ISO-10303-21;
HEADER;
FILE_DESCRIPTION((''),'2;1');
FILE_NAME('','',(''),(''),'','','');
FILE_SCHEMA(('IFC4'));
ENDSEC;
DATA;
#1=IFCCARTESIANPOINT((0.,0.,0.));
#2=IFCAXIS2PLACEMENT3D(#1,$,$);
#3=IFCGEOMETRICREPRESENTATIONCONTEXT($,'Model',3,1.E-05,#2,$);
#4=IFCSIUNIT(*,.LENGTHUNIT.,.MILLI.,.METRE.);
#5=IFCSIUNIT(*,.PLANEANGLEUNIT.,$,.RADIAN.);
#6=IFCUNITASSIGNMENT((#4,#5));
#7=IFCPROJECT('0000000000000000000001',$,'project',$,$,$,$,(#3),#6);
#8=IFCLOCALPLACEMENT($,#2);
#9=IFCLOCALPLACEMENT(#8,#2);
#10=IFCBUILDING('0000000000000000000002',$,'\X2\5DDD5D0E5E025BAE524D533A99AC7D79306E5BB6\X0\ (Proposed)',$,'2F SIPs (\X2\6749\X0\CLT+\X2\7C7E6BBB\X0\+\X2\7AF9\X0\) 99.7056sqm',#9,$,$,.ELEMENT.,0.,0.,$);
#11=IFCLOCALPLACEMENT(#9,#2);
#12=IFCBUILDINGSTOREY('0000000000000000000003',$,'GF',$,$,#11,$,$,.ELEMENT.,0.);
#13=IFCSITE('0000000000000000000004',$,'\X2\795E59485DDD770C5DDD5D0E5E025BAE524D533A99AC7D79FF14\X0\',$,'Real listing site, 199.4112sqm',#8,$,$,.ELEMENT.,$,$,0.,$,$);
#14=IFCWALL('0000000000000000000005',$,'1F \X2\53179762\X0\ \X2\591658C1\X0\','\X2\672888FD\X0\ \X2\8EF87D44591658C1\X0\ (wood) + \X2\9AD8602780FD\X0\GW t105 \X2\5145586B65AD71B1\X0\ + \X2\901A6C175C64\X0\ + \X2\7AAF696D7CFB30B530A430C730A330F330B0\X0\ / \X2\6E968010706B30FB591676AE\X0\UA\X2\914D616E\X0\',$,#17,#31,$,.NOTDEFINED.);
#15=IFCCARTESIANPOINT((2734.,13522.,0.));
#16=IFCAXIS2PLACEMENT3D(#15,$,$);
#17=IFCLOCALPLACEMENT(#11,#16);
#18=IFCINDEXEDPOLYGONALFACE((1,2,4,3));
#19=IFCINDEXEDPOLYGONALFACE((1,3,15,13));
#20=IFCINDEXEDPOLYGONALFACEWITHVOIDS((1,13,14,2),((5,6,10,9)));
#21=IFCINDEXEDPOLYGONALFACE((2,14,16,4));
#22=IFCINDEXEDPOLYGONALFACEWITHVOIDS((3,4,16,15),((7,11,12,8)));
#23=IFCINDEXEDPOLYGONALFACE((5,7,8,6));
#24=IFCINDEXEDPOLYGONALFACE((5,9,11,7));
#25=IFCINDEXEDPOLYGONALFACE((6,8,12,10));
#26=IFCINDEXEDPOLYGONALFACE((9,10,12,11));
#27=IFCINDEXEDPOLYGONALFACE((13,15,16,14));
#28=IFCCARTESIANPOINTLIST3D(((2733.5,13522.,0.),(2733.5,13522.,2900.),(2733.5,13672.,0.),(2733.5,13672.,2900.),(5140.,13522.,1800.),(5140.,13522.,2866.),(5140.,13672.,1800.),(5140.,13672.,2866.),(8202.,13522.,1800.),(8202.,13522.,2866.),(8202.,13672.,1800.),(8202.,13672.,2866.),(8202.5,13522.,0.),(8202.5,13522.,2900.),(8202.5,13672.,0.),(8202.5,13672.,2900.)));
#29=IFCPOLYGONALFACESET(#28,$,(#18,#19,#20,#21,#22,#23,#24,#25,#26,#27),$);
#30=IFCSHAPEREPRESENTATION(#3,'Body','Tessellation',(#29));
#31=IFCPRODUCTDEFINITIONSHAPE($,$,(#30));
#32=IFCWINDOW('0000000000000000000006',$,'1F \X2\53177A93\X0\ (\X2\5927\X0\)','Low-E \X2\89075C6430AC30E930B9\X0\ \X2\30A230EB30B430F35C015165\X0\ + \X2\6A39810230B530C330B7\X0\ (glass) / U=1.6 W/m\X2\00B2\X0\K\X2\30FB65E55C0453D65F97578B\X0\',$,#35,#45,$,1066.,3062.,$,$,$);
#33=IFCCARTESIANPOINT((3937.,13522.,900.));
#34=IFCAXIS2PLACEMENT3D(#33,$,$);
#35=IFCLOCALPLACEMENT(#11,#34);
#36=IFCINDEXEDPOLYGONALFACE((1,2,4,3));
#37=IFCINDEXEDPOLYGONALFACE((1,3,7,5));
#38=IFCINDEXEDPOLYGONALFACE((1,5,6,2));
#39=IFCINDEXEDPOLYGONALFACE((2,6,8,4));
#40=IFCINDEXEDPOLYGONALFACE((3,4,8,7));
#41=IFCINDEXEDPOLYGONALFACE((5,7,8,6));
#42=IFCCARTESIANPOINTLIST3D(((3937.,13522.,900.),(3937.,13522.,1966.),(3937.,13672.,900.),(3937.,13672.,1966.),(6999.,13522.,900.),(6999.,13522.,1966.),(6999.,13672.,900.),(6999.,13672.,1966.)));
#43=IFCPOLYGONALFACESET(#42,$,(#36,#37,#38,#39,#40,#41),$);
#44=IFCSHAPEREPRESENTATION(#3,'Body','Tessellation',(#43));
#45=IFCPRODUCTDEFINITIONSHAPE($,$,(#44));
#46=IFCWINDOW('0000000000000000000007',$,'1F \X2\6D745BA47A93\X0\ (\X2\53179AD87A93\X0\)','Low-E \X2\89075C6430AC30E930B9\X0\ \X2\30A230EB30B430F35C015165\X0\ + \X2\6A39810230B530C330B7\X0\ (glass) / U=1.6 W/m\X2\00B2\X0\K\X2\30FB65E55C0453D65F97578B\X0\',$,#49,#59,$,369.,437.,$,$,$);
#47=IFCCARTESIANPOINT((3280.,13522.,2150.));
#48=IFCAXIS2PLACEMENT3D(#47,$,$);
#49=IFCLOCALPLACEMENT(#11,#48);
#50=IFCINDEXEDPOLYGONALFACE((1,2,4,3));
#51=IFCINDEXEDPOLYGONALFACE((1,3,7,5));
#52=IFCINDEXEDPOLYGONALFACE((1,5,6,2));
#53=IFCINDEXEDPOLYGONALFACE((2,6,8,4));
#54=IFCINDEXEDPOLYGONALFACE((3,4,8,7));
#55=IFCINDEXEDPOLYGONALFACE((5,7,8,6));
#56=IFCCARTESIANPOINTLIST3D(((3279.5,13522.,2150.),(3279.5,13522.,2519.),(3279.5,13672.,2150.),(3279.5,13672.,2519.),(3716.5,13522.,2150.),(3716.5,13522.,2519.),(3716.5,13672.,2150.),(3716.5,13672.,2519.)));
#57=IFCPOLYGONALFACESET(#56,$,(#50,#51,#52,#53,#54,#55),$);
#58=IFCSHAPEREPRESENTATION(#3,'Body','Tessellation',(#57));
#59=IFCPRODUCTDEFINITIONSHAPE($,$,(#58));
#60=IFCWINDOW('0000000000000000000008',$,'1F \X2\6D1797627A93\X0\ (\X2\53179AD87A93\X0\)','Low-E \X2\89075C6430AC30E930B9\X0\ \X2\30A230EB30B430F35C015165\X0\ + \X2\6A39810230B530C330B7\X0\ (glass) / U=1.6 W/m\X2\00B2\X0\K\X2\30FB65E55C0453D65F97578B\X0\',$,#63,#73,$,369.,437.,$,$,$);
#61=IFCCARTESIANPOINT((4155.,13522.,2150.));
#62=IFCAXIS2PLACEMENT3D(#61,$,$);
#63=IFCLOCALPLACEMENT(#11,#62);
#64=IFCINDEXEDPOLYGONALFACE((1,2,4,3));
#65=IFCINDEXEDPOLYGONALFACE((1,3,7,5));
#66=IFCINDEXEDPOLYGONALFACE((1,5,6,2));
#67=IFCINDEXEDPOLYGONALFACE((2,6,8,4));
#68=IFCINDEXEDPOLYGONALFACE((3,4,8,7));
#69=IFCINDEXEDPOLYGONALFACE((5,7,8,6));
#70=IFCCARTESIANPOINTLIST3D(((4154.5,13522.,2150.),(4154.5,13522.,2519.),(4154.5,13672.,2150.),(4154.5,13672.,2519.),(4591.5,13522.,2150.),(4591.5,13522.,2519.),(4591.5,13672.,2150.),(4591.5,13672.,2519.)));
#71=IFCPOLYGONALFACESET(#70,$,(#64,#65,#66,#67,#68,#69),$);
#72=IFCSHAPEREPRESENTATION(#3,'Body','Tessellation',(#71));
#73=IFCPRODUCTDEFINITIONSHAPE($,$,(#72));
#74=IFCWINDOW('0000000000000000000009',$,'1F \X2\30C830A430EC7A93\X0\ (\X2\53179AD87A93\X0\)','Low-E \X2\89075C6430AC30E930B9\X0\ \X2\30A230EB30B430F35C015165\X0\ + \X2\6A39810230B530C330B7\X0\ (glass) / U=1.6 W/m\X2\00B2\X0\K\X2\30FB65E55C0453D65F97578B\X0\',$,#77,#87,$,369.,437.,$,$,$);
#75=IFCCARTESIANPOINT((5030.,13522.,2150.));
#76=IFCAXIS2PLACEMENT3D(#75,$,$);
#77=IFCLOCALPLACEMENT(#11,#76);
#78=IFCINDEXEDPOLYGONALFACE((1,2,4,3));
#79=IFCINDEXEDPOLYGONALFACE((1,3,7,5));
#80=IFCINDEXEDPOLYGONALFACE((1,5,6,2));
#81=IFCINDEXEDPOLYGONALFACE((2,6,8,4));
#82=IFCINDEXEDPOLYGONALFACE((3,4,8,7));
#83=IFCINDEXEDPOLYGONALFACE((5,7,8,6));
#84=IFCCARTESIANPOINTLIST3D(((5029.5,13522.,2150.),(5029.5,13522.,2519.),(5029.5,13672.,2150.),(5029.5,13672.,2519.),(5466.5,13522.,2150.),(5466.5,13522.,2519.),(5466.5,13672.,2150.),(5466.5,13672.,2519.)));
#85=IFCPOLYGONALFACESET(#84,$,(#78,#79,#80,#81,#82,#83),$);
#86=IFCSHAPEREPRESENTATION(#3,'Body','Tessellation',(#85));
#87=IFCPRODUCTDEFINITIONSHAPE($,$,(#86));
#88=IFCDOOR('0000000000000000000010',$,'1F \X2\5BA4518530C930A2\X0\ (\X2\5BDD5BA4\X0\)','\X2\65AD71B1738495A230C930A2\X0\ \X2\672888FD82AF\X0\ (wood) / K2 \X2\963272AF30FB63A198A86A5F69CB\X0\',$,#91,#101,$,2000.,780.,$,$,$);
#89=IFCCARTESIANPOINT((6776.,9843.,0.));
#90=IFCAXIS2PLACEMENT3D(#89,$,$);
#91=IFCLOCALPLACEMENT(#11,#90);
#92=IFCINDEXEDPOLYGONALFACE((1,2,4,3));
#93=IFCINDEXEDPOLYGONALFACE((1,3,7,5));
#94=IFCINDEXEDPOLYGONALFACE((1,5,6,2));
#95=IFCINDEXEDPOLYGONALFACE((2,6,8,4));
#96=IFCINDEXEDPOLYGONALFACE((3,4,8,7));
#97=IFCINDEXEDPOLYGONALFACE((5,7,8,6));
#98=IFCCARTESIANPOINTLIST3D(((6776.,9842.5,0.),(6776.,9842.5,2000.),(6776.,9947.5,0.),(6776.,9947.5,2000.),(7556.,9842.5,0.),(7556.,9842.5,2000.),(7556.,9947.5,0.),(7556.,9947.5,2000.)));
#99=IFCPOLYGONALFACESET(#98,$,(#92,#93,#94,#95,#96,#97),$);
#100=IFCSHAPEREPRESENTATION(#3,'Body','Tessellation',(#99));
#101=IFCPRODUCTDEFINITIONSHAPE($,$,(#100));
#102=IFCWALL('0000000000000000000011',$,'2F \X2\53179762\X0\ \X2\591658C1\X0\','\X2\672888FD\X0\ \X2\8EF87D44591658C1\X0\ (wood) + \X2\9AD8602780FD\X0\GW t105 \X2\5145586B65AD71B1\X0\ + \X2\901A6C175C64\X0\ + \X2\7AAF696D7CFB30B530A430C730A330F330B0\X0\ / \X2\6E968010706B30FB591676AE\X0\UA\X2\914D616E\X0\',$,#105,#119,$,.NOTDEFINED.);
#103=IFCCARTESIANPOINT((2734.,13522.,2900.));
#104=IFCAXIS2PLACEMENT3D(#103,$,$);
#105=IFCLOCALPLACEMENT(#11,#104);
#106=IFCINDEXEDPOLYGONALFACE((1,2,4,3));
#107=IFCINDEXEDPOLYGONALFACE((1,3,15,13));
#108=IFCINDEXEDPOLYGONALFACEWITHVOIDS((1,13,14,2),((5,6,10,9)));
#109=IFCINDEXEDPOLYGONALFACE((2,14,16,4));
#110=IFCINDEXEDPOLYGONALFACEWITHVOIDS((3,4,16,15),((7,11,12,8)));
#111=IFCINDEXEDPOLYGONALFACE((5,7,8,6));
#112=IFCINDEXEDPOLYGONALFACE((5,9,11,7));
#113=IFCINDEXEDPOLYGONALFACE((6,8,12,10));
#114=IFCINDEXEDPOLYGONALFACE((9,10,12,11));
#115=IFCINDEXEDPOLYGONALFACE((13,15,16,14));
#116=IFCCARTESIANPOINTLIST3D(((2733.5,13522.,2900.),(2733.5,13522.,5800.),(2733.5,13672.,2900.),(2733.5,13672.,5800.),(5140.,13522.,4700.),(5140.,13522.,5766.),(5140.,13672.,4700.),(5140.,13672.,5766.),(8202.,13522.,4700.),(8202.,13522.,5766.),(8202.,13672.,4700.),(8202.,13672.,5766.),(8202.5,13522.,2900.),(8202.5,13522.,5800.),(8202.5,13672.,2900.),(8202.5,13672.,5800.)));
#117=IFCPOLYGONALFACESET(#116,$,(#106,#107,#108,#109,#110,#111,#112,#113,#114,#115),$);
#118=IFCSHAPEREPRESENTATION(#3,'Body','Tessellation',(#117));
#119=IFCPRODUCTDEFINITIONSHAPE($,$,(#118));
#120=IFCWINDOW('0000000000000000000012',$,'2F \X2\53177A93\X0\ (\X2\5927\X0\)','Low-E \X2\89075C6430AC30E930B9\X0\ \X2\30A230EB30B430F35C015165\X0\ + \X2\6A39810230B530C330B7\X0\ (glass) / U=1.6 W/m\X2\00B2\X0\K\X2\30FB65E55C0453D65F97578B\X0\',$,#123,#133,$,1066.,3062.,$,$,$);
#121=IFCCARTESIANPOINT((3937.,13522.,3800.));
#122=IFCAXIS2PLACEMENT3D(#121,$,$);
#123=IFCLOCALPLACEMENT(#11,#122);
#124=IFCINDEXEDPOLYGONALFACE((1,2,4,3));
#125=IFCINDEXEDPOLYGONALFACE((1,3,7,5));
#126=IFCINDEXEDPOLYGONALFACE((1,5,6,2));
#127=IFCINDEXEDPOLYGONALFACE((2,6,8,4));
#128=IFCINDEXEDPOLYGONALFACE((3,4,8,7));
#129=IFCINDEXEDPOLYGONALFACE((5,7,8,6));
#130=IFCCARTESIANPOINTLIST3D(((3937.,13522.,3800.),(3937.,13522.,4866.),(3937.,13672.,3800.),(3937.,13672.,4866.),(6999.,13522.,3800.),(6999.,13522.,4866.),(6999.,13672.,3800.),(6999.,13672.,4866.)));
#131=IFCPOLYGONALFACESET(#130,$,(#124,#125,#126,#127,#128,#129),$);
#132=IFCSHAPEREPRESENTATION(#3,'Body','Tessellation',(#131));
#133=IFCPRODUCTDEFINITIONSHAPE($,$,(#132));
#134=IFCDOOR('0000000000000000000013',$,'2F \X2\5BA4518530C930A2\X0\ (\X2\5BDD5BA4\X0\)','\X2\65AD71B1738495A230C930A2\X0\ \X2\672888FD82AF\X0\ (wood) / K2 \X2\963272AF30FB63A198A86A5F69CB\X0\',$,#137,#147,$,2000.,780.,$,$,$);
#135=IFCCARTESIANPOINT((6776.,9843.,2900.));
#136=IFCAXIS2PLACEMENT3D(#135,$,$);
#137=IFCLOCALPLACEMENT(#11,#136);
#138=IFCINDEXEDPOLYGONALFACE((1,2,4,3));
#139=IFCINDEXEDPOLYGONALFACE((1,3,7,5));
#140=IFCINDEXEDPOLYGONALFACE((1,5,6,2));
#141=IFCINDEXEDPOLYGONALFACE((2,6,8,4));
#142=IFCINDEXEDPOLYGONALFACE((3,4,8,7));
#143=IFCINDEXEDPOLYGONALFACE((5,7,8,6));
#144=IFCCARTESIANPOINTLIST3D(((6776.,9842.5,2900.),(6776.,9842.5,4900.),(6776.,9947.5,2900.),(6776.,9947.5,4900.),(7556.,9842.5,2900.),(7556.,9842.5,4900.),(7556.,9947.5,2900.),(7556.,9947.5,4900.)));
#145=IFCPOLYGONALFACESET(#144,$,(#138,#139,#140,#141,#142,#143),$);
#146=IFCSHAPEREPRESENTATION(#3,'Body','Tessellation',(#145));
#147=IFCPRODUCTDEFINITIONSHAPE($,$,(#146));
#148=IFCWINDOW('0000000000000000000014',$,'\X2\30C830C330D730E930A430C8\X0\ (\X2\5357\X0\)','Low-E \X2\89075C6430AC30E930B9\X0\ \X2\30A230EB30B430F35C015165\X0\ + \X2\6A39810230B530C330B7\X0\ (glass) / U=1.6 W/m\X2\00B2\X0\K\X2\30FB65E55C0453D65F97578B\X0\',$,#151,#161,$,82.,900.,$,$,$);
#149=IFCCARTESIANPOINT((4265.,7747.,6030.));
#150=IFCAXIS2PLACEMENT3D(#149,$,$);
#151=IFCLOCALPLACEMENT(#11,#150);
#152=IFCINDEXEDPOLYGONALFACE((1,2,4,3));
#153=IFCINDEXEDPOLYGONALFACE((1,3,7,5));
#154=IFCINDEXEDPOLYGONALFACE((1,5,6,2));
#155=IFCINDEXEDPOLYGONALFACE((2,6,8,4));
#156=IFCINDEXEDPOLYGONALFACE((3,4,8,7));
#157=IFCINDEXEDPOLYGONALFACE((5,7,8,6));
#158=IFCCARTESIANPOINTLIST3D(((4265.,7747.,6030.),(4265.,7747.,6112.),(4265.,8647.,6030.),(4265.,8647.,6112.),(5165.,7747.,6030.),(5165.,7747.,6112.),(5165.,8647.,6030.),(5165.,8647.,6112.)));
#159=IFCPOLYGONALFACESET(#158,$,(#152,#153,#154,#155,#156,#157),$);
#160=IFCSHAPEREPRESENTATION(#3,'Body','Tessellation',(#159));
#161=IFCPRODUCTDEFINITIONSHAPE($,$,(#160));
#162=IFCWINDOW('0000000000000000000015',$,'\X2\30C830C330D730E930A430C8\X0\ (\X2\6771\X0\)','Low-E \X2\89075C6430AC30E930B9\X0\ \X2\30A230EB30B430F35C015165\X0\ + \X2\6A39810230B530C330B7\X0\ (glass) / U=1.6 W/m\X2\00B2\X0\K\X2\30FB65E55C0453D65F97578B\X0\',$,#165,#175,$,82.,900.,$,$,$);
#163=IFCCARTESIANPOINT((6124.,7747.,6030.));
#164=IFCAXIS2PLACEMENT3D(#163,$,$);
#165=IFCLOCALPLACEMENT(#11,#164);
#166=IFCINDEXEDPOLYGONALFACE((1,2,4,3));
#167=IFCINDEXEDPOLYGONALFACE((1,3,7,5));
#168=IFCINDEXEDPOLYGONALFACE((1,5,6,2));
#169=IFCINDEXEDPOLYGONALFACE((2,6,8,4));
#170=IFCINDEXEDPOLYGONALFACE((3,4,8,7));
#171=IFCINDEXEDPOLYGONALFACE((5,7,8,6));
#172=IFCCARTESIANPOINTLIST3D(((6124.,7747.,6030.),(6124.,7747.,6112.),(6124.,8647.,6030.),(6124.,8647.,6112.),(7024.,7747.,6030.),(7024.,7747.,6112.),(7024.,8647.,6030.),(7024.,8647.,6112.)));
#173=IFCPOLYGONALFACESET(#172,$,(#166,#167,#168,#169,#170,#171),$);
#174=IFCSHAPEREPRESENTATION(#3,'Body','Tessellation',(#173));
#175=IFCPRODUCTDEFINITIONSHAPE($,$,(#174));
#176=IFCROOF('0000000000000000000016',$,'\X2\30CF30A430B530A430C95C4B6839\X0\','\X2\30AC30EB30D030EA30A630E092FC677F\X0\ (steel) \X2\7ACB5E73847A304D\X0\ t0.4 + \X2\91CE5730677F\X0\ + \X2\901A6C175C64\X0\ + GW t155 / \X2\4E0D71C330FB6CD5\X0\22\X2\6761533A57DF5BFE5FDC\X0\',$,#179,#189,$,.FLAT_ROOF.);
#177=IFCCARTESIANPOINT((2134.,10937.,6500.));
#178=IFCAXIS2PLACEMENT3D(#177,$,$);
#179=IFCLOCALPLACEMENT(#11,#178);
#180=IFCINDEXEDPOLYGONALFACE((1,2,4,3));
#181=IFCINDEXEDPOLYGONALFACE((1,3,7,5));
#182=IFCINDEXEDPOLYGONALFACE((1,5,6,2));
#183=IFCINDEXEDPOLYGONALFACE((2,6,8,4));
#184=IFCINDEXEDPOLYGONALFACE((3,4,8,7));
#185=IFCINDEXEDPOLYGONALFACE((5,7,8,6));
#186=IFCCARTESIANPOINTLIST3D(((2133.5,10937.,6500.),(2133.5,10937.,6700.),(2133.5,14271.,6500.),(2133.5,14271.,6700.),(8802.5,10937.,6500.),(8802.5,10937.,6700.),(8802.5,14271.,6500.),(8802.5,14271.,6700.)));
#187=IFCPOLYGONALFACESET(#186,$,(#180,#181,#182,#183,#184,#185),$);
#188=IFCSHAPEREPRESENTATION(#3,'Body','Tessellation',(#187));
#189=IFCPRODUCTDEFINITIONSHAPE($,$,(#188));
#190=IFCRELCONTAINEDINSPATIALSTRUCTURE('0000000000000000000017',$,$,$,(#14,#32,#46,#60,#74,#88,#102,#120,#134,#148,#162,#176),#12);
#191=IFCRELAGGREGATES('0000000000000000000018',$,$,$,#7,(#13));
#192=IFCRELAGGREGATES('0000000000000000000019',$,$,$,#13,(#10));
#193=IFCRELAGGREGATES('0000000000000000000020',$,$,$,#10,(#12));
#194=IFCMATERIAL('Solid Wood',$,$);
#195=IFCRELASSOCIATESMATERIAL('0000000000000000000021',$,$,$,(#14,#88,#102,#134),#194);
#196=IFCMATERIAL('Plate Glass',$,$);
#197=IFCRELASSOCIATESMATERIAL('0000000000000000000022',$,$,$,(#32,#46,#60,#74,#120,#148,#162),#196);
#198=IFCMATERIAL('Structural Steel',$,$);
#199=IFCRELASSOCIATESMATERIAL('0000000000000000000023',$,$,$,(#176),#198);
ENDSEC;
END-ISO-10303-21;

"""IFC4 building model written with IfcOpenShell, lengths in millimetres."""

from ifc_helpers import new_model, si_unit, frame, frame_2d, origin, place, context, project, spatial, rectangle, extrude, material, element, fill, save


model = new_model("IFC4")

# Units and contexts
model_context = context("Model", 3, precision=1e-05, world=origin())
ifc_project = project(units=[si_unit("LENGTHUNIT", "METRE", prefix="MILLI"), si_unit("PLANEANGLEUNIT", "RADIAN")], contexts=[model_context])

# Site, building, storey
site_placement = place(None, origin())
site = spatial("IfcSite", under=ifc_project, at=site_placement, Name="神奈川県川崎市宮前区馬絹４", ObjectType="Real listing site, 199.4112sqm", CompositionType="ELEMENT", RefElevation=0.0)
building_placement = place(site_placement, origin())
building = spatial("IfcBuilding", under=site, at=building_placement, Name="川崎市宮前区馬絹の家 (Proposed)", ObjectType="2F SIPs (杉CLT+籾殻+竹) 99.7056sqm", CompositionType="ELEMENT", ElevationOfRefHeight=0.0, ElevationOfTerrain=0.0)
storey_placement = place(building_placement, origin())
storey = spatial("IfcBuildingStorey", under=building, at=storey_placement, Name="GF", CompositionType="ELEMENT", Elevation=0.0)

# Wall, openings, windows
ifc_material_1 = material(Name="Solid Wood")
wall_1_placement = place(storey_placement, frame((2734.0, 13522.0, 0.0)))
wall_1 = element("IfcWall", 1, at=wall_1_placement, inside=storey, material=ifc_material_1, Name="1F 北面 外壁", Description="木製 軸組外壁 (wood) + 高性能GW t105 充填断熱 + 通気層 + 窯業系サイディング / 準耐火・外皮UA配慮", PredefinedType="NOTDEFINED", context=model_context, shape_type="SweptSolid", body=[
    extrude(rectangle(XDim=5469.0, YDim=150.0, at=frame_2d((2734.0, 75.0))), frame((2734.0, 13522.0, 0.0)), (0.0, 0.0, 1.0), 2900.0),
])
opening_1_placement = place(storey_placement, frame((3937.0, 13522.0, 900.0)))
opening_1 = element("IfcOpeningElement", 2, at=opening_1_placement, cuts=wall_1, PredefinedType="NOTDEFINED", context=model_context, shape_type="SweptSolid", body=[
    extrude(rectangle(XDim=3062.0, YDim=150.0, at=frame_2d((1531.0, 75.0))), frame((3937.0, 13522.0, 900.0)), (0.0, 0.0, 1.0), 1066.0),
])
opening_2_placement = place(storey_placement, frame((3280.0, 13522.0, 2150.0)))
opening_2 = element("IfcOpeningElement", 3, at=opening_2_placement, cuts=wall_1, PredefinedType="NOTDEFINED", context=model_context, shape_type="SweptSolid", body=[
    extrude(rectangle(XDim=437.0, YDim=150.0, at=frame_2d((218.0, 75.0))), frame((3280.0, 13522.0, 2150.0)), (0.0, 0.0, 1.0), 369.0),
])
opening_3_placement = place(storey_placement, frame((4155.0, 13522.0, 2150.0)))
opening_3 = element("IfcOpeningElement", 4, at=opening_3_placement, cuts=wall_1, PredefinedType="NOTDEFINED", context=model_context, shape_type="SweptSolid", body=[
    extrude(rectangle(XDim=437.0, YDim=150.0, at=frame_2d((218.0, 75.0))), frame((4155.0, 13522.0, 2150.0)), (0.0, 0.0, 1.0), 369.0),
])
opening_4_placement = place(storey_placement, frame((5030.0, 13522.0, 2150.0)))
opening_4 = element("IfcOpeningElement", 5, at=opening_4_placement, cuts=wall_1, PredefinedType="NOTDEFINED", context=model_context, shape_type="SweptSolid", body=[
    extrude(rectangle(XDim=437.0, YDim=150.0, at=frame_2d((218.0, 75.0))), frame((5030.0, 13522.0, 2150.0)), (0.0, 0.0, 1.0), 369.0),
])
ifc_material_2 = material(Name="Plate Glass")
window_1_placement = place(storey_placement, frame((3937.0, 13522.0, 900.0)))
window_1 = element("IfcWindow", 6, at=window_1_placement, inside=storey, material=ifc_material_2, Name="1F 北窓 (大)", Description="Low-E 複層ガラス アルゴン封入 + 樹脂サッシ (glass) / U=1.6 W/m²K・日射取得型", OverallHeight=1066.0, OverallWidth=3062.0, context=model_context, shape_type="SweptSolid", body=[
    extrude(rectangle(XDim=3062.0, YDim=150.0, at=frame_2d((1531.0, 75.0))), frame((3937.0, 13522.0, 900.0)), (0.0, 0.0, 1.0), 1066.0),
])
fill(opening_1, window_1)
window_2_placement = place(storey_placement, frame((3280.0, 13522.0, 2150.0)))
window_2 = element("IfcWindow", 7, at=window_2_placement, inside=storey, material=ifc_material_2, Name="1F 浴室窓 (北高窓)", Description="Low-E 複層ガラス アルゴン封入 + 樹脂サッシ (glass) / U=1.6 W/m²K・日射取得型", OverallHeight=369.0, OverallWidth=437.0, context=model_context, shape_type="SweptSolid", body=[
    extrude(rectangle(XDim=437.0, YDim=150.0, at=frame_2d((218.0, 75.0))), frame((3280.0, 13522.0, 2150.0)), (0.0, 0.0, 1.0), 369.0),
])
fill(opening_2, window_2)
window_3_placement = place(storey_placement, frame((4155.0, 13522.0, 2150.0)))
window_3 = element("IfcWindow", 8, at=window_3_placement, inside=storey, material=ifc_material_2, Name="1F 洗面窓 (北高窓)", Description="Low-E 複層ガラス アルゴン封入 + 樹脂サッシ (glass) / U=1.6 W/m²K・日射取得型", OverallHeight=369.0, OverallWidth=437.0, context=model_context, shape_type="SweptSolid", body=[
    extrude(rectangle(XDim=437.0, YDim=150.0, at=frame_2d((218.0, 75.0))), frame((4155.0, 13522.0, 2150.0)), (0.0, 0.0, 1.0), 369.0),
])
fill(opening_3, window_3)
window_4_placement = place(storey_placement, frame((5030.0, 13522.0, 2150.0)))
window_4 = element("IfcWindow", 9, at=window_4_placement, inside=storey, material=ifc_material_2, Name="1F トイレ窓 (北高窓)", Description="Low-E 複層ガラス アルゴン封入 + 樹脂サッシ (glass) / U=1.6 W/m²K・日射取得型", OverallHeight=369.0, OverallWidth=437.0, context=model_context, shape_type="SweptSolid", body=[
    extrude(rectangle(XDim=437.0, YDim=150.0, at=frame_2d((218.0, 75.0))), frame((5030.0, 13522.0, 2150.0)), (0.0, 0.0, 1.0), 369.0),
])
fill(opening_4, window_4)

# Door
door_1_placement = place(storey_placement, frame((6776.0, 9843.0, 0.0)))
element("IfcDoor", 10, at=door_1_placement, inside=storey, material=ifc_material_1, Name="1F 室内ドア (寝室)", Description="断熱玄関ドア 木製芯 (wood) / K2 防犯・採風機構", OverallHeight=2000.0, OverallWidth=780.0, context=model_context, shape_type="SweptSolid", body=[
    extrude(rectangle(XDim=780.0, YDim=105.0, at=frame_2d((390.0, 52.0))), frame((6776.0, 9843.0, 0.0)), (0.0, 0.0, 1.0), 2000.0),
])

# Wall, opening, window
wall_2_placement = place(storey_placement, frame((2734.0, 13522.0, 2900.0)))
wall_2 = element("IfcWall", 11, at=wall_2_placement, inside=storey, material=ifc_material_1, Name="2F 北面 外壁", Description="木製 軸組外壁 (wood) + 高性能GW t105 充填断熱 + 通気層 + 窯業系サイディング / 準耐火・外皮UA配慮", PredefinedType="NOTDEFINED", context=model_context, shape_type="SweptSolid", body=[
    extrude(rectangle(XDim=5469.0, YDim=150.0, at=frame_2d((2734.0, 75.0))), frame((2734.0, 13522.0, 2900.0)), (0.0, 0.0, 1.0), 2900.0),
])
opening_5_placement = place(storey_placement, frame((3937.0, 13522.0, 3800.0)))
opening_5 = element("IfcOpeningElement", 12, at=opening_5_placement, cuts=wall_2, PredefinedType="NOTDEFINED", context=model_context, shape_type="SweptSolid", body=[
    extrude(rectangle(XDim=3062.0, YDim=150.0, at=frame_2d((1531.0, 75.0))), frame((3937.0, 13522.0, 3800.0)), (0.0, 0.0, 1.0), 1066.0),
])
window_5_placement = place(storey_placement, frame((3937.0, 13522.0, 3800.0)))
window_5 = element("IfcWindow", 13, at=window_5_placement, inside=storey, material=ifc_material_2, Name="2F 北窓 (大)", Description="Low-E 複層ガラス アルゴン封入 + 樹脂サッシ (glass) / U=1.6 W/m²K・日射取得型", OverallHeight=1066.0, OverallWidth=3062.0, context=model_context, shape_type="SweptSolid", body=[
    extrude(rectangle(XDim=3062.0, YDim=150.0, at=frame_2d((1531.0, 75.0))), frame((3937.0, 13522.0, 3800.0)), (0.0, 0.0, 1.0), 1066.0),
])
fill(opening_5, window_5)

# Door
door_2_placement = place(storey_placement, frame((6776.0, 9843.0, 2900.0)))
element("IfcDoor", 14, at=door_2_placement, inside=storey, material=ifc_material_1, Name="2F 室内ドア (寝室)", Description="断熱玄関ドア 木製芯 (wood) / K2 防犯・採風機構", OverallHeight=2000.0, OverallWidth=780.0, context=model_context, shape_type="SweptSolid", body=[
    extrude(rectangle(XDim=780.0, YDim=105.0, at=frame_2d((390.0, 52.0))), frame((6776.0, 9843.0, 2900.0)), (0.0, 0.0, 1.0), 2000.0),
])

# Windows
window_6_placement = place(storey_placement, frame((4265.0, 7747.0, 6030.0)))
element("IfcWindow", 15, at=window_6_placement, inside=storey, material=ifc_material_2, Name="トップライト (南)", Description="Low-E 複層ガラス アルゴン封入 + 樹脂サッシ (glass) / U=1.6 W/m²K・日射取得型", OverallHeight=82.0, OverallWidth=900.0, context=model_context, shape_type="SweptSolid", body=[
    extrude(rectangle(XDim=900.0, YDim=900.0, at=frame_2d((450.0, 450.0))), frame((4265.0, 7747.0, 6030.0)), (0.0, 0.0, 1.0), 82.0),
])
window_7_placement = place(storey_placement, frame((6124.0, 7747.0, 6030.0)))
element("IfcWindow", 16, at=window_7_placement, inside=storey, material=ifc_material_2, Name="トップライト (東)", Description="Low-E 複層ガラス アルゴン封入 + 樹脂サッシ (glass) / U=1.6 W/m²K・日射取得型", OverallHeight=82.0, OverallWidth=900.0, context=model_context, shape_type="SweptSolid", body=[
    extrude(rectangle(XDim=900.0, YDim=900.0, at=frame_2d((450.0, 450.0))), frame((6124.0, 7747.0, 6030.0)), (0.0, 0.0, 1.0), 82.0),
])

# Roof
ifc_material_3 = material(Name="Structural Steel")
roof_placement = place(storey_placement, frame((2134.0, 10937.0, 6500.0)))
element("IfcRoof", 17, at=roof_placement, inside=storey, material=ifc_material_3, Name="ハイサイド屋根", Description="ガルバリウム鋼板 (steel) 立平葺き t0.4 + 野地板 + 通気層 + GW t155 / 不燃・法22条区域対応", PredefinedType="FLAT_ROOF", context=model_context, shape_type="SweptSolid", body=[
    extrude(rectangle(XDim=6669.0, YDim=3334.0, at=frame_2d((3334.0, 1667.0))), frame((2134.0, 10937.0, 6500.0)), (0.0, 0.0, 1.0), 200.0),
])

save(model, "model.ifc")
